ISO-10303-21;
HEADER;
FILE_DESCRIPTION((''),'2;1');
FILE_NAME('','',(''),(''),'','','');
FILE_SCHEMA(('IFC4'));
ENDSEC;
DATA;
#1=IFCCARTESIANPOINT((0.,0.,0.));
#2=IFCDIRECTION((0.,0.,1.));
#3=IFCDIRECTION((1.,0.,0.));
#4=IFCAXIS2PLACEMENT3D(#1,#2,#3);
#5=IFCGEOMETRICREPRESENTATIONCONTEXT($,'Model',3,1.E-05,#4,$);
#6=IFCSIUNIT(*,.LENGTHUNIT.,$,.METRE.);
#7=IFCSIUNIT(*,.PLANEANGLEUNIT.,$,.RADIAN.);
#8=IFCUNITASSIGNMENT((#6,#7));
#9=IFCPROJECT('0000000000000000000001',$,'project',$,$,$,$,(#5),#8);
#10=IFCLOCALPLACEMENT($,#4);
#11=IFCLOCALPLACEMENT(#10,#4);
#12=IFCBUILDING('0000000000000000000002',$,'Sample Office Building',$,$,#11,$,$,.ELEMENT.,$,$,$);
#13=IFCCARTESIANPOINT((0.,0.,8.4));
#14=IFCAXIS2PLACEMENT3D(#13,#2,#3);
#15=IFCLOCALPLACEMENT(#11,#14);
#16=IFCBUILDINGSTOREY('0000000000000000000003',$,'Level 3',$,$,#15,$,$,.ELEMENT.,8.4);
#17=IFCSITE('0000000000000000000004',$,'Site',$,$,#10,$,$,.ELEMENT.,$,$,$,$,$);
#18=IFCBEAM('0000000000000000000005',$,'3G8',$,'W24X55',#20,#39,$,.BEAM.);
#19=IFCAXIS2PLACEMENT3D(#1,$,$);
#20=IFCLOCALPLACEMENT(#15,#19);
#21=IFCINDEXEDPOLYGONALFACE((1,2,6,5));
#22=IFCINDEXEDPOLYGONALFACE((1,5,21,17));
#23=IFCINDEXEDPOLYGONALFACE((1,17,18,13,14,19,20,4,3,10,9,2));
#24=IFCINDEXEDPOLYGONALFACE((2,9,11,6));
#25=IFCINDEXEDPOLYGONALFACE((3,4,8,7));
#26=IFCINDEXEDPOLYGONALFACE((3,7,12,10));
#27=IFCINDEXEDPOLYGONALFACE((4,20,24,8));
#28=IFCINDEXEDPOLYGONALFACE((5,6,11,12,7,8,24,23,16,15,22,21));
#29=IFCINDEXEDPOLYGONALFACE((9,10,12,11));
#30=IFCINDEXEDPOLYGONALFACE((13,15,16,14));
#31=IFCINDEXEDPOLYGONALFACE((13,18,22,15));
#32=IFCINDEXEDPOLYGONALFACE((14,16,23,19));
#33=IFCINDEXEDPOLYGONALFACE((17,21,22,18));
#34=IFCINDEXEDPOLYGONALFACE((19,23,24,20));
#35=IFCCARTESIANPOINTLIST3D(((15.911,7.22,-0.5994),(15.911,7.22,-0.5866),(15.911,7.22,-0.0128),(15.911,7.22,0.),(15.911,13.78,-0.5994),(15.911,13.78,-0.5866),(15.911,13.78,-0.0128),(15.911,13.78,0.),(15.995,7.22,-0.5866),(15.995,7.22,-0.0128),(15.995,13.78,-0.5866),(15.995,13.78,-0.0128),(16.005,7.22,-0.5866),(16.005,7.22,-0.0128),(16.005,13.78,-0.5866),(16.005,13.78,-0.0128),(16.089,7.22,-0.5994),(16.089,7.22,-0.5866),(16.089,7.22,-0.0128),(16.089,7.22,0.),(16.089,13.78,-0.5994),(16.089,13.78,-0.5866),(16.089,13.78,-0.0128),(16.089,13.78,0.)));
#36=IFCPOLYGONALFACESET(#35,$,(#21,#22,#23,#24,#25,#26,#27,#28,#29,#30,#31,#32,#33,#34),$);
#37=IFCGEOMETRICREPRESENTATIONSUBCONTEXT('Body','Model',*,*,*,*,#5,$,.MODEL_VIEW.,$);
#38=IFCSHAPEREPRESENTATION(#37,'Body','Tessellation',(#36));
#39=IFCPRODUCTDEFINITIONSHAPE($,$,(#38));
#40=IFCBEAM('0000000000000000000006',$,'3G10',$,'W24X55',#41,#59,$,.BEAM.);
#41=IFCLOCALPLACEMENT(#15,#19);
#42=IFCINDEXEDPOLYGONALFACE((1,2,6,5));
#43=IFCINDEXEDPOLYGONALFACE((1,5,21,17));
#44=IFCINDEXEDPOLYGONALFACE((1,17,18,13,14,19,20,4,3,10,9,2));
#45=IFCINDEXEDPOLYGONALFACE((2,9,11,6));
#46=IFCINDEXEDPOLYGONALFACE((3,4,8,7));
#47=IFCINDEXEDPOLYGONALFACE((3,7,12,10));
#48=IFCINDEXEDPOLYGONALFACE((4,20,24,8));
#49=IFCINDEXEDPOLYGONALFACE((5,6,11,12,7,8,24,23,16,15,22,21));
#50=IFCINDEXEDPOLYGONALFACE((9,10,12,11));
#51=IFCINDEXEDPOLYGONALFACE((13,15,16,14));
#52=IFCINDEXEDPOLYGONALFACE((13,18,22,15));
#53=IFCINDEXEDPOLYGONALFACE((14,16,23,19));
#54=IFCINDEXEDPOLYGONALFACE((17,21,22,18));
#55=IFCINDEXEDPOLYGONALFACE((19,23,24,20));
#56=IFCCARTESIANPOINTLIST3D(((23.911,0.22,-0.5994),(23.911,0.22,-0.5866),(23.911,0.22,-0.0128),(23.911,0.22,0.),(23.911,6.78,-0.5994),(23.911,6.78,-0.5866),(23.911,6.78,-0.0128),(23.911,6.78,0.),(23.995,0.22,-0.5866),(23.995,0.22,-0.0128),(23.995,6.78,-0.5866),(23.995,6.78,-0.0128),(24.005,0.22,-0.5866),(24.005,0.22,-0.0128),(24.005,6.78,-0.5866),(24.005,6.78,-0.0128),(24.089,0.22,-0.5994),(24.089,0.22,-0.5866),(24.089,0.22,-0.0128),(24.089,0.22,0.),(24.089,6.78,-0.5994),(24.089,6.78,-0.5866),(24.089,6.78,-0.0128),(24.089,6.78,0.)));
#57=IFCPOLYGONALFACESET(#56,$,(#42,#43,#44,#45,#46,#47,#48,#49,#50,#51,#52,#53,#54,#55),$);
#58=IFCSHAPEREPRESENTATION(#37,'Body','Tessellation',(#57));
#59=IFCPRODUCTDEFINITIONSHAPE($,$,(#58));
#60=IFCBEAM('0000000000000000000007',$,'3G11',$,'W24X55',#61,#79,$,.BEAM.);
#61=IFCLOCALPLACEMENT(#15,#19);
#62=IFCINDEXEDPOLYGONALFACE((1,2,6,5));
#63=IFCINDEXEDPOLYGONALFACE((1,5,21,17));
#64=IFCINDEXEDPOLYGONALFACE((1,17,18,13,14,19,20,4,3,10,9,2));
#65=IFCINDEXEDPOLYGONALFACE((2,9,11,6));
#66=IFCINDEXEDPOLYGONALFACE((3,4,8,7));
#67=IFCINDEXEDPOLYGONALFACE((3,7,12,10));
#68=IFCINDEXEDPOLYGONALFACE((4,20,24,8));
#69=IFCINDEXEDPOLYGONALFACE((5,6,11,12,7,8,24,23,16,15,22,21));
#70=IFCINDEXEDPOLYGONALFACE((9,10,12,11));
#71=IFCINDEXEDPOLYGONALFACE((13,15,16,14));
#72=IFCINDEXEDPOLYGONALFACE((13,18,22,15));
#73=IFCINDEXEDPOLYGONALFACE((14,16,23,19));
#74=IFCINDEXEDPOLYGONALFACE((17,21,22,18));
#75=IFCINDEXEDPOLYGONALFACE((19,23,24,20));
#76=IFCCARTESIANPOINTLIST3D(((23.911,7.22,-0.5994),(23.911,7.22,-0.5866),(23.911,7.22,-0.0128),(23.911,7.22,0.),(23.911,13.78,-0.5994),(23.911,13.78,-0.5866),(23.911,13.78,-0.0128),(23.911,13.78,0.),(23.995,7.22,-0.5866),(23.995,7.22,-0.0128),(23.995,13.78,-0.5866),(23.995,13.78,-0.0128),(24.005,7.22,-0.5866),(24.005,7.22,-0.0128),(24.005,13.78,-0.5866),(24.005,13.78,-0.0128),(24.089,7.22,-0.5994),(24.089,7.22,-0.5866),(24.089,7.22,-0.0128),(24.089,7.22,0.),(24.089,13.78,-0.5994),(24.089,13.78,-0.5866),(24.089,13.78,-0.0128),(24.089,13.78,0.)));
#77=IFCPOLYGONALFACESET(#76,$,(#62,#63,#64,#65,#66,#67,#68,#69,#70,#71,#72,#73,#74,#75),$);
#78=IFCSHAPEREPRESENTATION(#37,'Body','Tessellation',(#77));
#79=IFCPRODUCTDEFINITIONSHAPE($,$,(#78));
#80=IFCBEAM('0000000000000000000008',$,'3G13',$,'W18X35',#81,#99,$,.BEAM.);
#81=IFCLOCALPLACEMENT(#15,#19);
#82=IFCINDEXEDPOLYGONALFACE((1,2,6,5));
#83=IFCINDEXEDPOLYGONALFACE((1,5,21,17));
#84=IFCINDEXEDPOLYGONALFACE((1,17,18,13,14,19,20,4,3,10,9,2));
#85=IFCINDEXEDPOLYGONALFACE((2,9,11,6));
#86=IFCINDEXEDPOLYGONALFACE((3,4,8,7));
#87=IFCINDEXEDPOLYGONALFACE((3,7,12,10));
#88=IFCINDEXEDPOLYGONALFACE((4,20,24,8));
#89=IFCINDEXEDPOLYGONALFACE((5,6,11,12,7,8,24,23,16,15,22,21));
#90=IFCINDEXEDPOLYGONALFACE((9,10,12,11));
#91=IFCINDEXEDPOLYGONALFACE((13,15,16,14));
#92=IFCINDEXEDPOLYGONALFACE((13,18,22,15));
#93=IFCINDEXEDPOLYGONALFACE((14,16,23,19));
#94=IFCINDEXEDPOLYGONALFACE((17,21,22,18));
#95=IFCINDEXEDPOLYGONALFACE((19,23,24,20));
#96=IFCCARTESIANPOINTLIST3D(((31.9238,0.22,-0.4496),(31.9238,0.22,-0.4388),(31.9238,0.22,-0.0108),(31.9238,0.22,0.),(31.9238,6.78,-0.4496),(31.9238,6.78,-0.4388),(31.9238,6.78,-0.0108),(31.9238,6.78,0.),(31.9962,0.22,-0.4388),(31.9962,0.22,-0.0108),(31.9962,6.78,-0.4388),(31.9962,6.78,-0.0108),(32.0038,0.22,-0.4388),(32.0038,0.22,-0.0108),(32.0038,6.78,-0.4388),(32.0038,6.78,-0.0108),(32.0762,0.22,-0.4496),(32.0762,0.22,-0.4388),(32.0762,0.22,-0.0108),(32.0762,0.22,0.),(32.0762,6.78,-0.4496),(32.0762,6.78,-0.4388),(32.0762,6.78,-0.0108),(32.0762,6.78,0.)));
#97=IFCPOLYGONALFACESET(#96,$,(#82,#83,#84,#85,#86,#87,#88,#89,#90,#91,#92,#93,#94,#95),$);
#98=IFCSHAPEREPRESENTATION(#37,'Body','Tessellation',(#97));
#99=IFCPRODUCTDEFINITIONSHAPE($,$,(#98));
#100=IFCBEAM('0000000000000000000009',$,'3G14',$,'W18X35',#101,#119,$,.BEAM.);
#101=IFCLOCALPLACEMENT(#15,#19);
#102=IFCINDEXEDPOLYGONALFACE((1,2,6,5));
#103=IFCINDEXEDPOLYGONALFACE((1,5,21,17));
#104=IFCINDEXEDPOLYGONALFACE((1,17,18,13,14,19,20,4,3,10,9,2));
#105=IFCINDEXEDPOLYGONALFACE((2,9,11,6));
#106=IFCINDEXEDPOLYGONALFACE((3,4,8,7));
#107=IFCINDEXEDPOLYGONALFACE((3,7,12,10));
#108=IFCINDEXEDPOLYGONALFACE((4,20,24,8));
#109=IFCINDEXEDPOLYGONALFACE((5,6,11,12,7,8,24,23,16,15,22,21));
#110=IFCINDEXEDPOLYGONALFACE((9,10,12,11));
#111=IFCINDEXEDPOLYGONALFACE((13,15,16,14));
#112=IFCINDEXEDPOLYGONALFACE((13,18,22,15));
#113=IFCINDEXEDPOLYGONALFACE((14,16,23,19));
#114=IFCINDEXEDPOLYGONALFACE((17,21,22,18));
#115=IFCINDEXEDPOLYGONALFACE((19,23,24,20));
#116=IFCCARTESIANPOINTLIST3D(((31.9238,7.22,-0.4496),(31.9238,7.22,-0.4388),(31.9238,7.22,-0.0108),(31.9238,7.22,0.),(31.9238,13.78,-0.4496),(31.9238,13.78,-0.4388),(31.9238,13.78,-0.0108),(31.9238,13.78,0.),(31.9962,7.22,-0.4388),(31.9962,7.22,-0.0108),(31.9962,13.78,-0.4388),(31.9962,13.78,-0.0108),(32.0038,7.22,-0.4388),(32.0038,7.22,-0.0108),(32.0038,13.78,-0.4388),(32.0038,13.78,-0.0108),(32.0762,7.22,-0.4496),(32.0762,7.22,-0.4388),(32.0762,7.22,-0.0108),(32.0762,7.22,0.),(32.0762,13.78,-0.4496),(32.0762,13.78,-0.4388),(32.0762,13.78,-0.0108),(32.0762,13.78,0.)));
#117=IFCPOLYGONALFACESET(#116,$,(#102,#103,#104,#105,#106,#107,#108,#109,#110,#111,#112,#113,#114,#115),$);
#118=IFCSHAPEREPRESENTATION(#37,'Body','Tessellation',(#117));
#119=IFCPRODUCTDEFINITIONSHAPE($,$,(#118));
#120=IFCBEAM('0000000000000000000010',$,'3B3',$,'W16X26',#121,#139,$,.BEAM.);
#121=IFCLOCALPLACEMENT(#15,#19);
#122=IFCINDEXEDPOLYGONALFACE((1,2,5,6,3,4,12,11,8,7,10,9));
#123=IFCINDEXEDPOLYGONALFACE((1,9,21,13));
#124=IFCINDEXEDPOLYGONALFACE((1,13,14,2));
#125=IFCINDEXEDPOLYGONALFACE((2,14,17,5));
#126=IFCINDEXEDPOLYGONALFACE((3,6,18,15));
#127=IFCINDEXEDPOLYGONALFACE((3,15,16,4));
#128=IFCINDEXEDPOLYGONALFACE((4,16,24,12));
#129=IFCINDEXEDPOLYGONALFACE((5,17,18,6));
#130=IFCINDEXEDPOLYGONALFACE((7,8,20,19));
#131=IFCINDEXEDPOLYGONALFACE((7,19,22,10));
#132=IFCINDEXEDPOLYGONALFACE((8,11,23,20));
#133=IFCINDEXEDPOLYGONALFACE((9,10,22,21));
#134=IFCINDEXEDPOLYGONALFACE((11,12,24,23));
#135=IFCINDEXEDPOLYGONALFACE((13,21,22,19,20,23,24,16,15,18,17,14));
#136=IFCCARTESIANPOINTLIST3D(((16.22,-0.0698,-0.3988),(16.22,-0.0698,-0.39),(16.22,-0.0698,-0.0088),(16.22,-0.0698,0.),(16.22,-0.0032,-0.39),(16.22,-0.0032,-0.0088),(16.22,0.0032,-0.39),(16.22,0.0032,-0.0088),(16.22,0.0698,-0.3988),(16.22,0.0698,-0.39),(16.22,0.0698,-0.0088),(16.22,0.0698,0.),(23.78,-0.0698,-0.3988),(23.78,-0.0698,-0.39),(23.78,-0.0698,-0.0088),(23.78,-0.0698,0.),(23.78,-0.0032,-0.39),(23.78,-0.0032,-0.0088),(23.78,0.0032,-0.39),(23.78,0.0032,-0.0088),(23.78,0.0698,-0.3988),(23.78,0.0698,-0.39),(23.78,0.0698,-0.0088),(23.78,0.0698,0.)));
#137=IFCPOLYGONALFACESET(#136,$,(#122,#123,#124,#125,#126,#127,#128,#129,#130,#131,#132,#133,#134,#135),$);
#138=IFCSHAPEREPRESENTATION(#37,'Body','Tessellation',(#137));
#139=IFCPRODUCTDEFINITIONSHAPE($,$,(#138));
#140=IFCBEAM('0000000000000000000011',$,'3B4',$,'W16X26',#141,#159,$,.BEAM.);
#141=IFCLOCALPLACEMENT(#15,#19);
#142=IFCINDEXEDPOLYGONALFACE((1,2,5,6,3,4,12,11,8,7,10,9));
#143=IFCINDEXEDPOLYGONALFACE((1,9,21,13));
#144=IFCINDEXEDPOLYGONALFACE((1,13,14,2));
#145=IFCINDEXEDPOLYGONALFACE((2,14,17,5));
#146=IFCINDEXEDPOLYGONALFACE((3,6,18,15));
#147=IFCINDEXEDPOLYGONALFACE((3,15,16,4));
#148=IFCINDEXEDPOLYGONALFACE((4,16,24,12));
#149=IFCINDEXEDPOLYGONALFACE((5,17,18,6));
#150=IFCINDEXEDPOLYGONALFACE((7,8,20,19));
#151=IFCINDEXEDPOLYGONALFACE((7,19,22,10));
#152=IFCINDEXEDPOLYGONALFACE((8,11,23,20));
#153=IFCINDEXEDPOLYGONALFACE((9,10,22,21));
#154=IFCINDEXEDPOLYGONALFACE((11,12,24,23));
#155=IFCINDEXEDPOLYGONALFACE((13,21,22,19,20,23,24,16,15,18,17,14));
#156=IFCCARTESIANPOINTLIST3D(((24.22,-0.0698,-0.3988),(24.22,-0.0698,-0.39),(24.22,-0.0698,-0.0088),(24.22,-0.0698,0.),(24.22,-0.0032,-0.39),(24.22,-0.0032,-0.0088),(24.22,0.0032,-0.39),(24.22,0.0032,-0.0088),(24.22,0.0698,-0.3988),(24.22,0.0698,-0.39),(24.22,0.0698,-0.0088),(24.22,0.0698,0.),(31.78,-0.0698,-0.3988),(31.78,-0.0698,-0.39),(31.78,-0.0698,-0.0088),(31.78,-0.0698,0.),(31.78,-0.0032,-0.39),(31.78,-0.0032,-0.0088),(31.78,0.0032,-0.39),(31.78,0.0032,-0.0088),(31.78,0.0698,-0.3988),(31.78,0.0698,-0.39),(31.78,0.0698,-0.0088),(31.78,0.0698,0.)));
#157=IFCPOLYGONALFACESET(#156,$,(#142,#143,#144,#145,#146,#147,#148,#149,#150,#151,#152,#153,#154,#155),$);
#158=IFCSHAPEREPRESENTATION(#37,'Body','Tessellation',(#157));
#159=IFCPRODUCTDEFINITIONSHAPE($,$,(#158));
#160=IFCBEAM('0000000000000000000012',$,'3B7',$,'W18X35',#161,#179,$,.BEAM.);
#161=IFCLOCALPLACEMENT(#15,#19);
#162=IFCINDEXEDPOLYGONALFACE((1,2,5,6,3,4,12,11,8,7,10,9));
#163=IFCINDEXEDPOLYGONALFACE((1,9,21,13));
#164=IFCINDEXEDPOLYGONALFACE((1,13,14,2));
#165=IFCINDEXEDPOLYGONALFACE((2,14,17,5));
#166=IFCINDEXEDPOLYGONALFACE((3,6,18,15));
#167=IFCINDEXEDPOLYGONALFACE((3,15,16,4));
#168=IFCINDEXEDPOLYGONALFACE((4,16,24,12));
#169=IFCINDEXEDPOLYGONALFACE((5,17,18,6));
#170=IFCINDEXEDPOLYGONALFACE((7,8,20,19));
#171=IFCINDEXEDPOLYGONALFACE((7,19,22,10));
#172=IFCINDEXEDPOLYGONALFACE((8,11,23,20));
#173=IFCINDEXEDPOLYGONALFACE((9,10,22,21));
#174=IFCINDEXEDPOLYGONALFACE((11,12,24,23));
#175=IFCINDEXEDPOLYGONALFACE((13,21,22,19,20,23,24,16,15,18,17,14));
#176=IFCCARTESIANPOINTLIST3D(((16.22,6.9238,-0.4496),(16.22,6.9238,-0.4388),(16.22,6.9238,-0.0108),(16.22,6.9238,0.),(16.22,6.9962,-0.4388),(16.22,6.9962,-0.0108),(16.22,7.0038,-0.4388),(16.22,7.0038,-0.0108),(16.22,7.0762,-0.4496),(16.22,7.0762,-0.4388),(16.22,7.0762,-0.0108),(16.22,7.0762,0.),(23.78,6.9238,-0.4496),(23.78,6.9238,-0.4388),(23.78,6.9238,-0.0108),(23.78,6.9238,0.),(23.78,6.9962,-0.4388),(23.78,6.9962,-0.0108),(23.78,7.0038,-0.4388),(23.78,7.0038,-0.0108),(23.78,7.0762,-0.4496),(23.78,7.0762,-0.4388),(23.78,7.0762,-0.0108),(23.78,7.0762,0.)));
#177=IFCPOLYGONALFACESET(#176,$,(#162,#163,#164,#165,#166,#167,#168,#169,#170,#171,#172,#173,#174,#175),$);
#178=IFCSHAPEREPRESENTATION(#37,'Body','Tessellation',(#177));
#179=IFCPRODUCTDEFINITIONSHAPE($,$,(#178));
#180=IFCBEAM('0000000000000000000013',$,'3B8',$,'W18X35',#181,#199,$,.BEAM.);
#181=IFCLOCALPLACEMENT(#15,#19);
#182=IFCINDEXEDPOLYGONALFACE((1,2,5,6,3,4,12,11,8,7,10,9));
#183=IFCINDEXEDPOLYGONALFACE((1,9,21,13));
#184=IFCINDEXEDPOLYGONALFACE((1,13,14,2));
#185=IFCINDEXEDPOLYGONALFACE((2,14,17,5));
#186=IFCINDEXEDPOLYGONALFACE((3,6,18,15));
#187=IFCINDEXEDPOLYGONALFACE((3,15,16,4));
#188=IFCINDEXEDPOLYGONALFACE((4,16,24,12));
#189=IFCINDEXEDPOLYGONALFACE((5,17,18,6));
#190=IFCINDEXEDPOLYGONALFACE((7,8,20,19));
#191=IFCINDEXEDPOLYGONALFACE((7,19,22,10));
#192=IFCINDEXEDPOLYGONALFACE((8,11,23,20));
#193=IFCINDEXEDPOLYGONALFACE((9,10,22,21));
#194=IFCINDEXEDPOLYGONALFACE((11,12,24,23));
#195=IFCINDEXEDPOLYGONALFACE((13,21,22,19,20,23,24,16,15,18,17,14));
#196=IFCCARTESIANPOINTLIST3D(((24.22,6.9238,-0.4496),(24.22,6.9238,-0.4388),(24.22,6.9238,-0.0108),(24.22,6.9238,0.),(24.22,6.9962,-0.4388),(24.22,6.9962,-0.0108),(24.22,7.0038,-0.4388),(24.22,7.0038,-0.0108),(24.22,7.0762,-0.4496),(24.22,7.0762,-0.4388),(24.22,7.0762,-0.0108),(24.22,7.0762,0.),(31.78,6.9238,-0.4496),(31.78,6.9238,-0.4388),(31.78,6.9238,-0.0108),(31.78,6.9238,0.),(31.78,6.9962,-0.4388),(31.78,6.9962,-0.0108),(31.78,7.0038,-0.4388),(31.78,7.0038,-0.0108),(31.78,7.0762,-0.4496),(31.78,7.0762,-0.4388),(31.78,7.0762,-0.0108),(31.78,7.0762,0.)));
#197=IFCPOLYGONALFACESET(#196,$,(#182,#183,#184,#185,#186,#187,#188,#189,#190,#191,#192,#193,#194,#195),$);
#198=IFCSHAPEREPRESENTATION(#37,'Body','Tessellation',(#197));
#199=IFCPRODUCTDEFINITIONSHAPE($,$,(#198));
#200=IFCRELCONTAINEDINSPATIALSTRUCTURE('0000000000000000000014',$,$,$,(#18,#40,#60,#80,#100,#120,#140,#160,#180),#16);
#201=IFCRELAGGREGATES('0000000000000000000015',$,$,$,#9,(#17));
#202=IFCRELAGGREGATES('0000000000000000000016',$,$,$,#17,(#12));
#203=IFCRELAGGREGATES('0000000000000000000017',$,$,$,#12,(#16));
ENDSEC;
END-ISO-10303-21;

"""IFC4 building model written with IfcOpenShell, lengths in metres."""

from ifc_helpers import new_model, si_unit, frame, origin_with_axes, place, context, subcontext, project, spatial, i_section, extrude, element, save


model = new_model("IFC4")

# Units and contexts
model_context = context("Model", 3, precision=1e-05, world=origin_with_axes())
body_context = subcontext(model_context, "Body", "Model", "MODEL_VIEW")
ifc_project = project(units=[si_unit("LENGTHUNIT", "METRE"), si_unit("PLANEANGLEUNIT", "RADIAN")], contexts=[model_context])

# Site, building, storey
site_placement = place(None, origin_with_axes())
site = spatial("IfcSite", under=ifc_project, at=site_placement, Name="Site", CompositionType="ELEMENT")
building_placement = place(site_placement, origin_with_axes())
building = spatial("IfcBuilding", under=site, at=building_placement, Name="Sample Office Building", CompositionType="ELEMENT")
storey_placement = place(building_placement, frame((0.0, 0.0, 8.4), z_axis=(0.0, 0.0, 1.0), x_axis=(1.0, 0.0, 0.0)))
storey = spatial("IfcBuildingStorey", under=building, at=storey_placement, Name="Level 3", CompositionType="ELEMENT", Elevation=8.4)

# Beams
beam_1_placement = place(None, frame((16.0, 7.22, 8.1003), z_axis=(0.0, 1.0, 0.0), x_axis=(-1.0, 0.0, 0.0)))
element("IfcBeam", 1, at=beam_1_placement, inside=storey, Name="3G8", ObjectType="W24X55", PredefinedType="BEAM", context=body_context, shape_type="SweptSolid", body=[
    extrude(i_section(OverallWidth=0.1781, OverallDepth=0.5994, WebThickness=0.01, FlangeThickness=0.0128), None, (0.0, 0.0, 1.0), 6.56),
])
beam_2_placement = place(None, frame((24.0, 0.22, 8.1003), z_axis=(0.0, 1.0, 0.0), x_axis=(-1.0, 0.0, 0.0)))
element("IfcBeam", 2, at=beam_2_placement, inside=storey, Name="3G10", ObjectType="W24X55", PredefinedType="BEAM", context=body_context, shape_type="SweptSolid", body=[
    extrude(i_section(OverallWidth=0.1781, OverallDepth=0.5994, WebThickness=0.01, FlangeThickness=0.0128), None, (0.0, 0.0, 1.0), 6.56),
])
beam_3_placement = place(None, frame((24.0, 7.22, 8.1003), z_axis=(0.0, 1.0, 0.0), x_axis=(-1.0, 0.0, 0.0)))
element("IfcBeam", 3, at=beam_3_placement, inside=storey, Name="3G11", ObjectType="W24X55", PredefinedType="BEAM", context=body_context, shape_type="SweptSolid", body=[
    extrude(i_section(OverallWidth=0.1781, OverallDepth=0.5994, WebThickness=0.01, FlangeThickness=0.0128), None, (0.0, 0.0, 1.0), 6.56),
])
beam_4_placement = place(None, frame((32.0, 0.22, 8.1752), z_axis=(0.0, 1.0, 0.0), x_axis=(-1.0, 0.0, 0.0)))
element("IfcBeam", 4, at=beam_4_placement, inside=storey, Name="3G13", ObjectType="W18X35", PredefinedType="BEAM", context=body_context, shape_type="SweptSolid", body=[
    extrude(i_section(OverallWidth=0.1524, OverallDepth=0.4496, WebThickness=0.0076, FlangeThickness=0.0108), None, (0.0, 0.0, 1.0), 6.56),
])
beam_5_placement = place(None, frame((32.0, 7.22, 8.1752), z_axis=(0.0, 1.0, 0.0), x_axis=(-1.0, 0.0, 0.0)))
element("IfcBeam", 5, at=beam_5_placement, inside=storey, Name="3G14", ObjectType="W18X35", PredefinedType="BEAM", context=body_context, shape_type="SweptSolid", body=[
    extrude(i_section(OverallWidth=0.1524, OverallDepth=0.4496, WebThickness=0.0076, FlangeThickness=0.0108), None, (0.0, 0.0, 1.0), 6.56),
])
for number, where, z_axis, x_axis, name in (
    (6, (16.22, 0.0, 8.2006), (1.0, 0.0, 0.0), (0.0, 1.0, 0.0), "3B3"),
    (7, (24.22, 0.0, 8.2006), (1.0, 0.0, 0.0), (0.0, 1.0, 0.0), "3B4"),
):
    element("IfcBeam", number, at=place(None, frame(where, z_axis=z_axis, x_axis=x_axis)), inside=storey, Name=name, ObjectType="W16X26", PredefinedType="BEAM", context=body_context, shape_type="SweptSolid", body=[
        extrude(i_section(OverallWidth=0.1397, OverallDepth=0.3988, WebThickness=0.0063, FlangeThickness=0.0088), None, (0.0, 0.0, 1.0), 7.56),
    ])
for number, where, z_axis, x_axis, name in (
    (8, (16.22, 7.0, 8.1752), (1.0, 0.0, 0.0), (0.0, 1.0, 0.0), "3B7"),
    (9, (24.22, 7.0, 8.1752), (1.0, 0.0, 0.0), (0.0, 1.0, 0.0), "3B8"),
):
    element("IfcBeam", number, at=place(None, frame(where, z_axis=z_axis, x_axis=x_axis)), inside=storey, Name=name, ObjectType="W18X35", PredefinedType="BEAM", context=body_context, shape_type="SweptSolid", body=[
        extrude(i_section(OverallWidth=0.1524, OverallDepth=0.4496, WebThickness=0.0076, FlangeThickness=0.0108), None, (0.0, 0.0, 1.0), 7.56),
    ])

save(model, "model.ifc")
